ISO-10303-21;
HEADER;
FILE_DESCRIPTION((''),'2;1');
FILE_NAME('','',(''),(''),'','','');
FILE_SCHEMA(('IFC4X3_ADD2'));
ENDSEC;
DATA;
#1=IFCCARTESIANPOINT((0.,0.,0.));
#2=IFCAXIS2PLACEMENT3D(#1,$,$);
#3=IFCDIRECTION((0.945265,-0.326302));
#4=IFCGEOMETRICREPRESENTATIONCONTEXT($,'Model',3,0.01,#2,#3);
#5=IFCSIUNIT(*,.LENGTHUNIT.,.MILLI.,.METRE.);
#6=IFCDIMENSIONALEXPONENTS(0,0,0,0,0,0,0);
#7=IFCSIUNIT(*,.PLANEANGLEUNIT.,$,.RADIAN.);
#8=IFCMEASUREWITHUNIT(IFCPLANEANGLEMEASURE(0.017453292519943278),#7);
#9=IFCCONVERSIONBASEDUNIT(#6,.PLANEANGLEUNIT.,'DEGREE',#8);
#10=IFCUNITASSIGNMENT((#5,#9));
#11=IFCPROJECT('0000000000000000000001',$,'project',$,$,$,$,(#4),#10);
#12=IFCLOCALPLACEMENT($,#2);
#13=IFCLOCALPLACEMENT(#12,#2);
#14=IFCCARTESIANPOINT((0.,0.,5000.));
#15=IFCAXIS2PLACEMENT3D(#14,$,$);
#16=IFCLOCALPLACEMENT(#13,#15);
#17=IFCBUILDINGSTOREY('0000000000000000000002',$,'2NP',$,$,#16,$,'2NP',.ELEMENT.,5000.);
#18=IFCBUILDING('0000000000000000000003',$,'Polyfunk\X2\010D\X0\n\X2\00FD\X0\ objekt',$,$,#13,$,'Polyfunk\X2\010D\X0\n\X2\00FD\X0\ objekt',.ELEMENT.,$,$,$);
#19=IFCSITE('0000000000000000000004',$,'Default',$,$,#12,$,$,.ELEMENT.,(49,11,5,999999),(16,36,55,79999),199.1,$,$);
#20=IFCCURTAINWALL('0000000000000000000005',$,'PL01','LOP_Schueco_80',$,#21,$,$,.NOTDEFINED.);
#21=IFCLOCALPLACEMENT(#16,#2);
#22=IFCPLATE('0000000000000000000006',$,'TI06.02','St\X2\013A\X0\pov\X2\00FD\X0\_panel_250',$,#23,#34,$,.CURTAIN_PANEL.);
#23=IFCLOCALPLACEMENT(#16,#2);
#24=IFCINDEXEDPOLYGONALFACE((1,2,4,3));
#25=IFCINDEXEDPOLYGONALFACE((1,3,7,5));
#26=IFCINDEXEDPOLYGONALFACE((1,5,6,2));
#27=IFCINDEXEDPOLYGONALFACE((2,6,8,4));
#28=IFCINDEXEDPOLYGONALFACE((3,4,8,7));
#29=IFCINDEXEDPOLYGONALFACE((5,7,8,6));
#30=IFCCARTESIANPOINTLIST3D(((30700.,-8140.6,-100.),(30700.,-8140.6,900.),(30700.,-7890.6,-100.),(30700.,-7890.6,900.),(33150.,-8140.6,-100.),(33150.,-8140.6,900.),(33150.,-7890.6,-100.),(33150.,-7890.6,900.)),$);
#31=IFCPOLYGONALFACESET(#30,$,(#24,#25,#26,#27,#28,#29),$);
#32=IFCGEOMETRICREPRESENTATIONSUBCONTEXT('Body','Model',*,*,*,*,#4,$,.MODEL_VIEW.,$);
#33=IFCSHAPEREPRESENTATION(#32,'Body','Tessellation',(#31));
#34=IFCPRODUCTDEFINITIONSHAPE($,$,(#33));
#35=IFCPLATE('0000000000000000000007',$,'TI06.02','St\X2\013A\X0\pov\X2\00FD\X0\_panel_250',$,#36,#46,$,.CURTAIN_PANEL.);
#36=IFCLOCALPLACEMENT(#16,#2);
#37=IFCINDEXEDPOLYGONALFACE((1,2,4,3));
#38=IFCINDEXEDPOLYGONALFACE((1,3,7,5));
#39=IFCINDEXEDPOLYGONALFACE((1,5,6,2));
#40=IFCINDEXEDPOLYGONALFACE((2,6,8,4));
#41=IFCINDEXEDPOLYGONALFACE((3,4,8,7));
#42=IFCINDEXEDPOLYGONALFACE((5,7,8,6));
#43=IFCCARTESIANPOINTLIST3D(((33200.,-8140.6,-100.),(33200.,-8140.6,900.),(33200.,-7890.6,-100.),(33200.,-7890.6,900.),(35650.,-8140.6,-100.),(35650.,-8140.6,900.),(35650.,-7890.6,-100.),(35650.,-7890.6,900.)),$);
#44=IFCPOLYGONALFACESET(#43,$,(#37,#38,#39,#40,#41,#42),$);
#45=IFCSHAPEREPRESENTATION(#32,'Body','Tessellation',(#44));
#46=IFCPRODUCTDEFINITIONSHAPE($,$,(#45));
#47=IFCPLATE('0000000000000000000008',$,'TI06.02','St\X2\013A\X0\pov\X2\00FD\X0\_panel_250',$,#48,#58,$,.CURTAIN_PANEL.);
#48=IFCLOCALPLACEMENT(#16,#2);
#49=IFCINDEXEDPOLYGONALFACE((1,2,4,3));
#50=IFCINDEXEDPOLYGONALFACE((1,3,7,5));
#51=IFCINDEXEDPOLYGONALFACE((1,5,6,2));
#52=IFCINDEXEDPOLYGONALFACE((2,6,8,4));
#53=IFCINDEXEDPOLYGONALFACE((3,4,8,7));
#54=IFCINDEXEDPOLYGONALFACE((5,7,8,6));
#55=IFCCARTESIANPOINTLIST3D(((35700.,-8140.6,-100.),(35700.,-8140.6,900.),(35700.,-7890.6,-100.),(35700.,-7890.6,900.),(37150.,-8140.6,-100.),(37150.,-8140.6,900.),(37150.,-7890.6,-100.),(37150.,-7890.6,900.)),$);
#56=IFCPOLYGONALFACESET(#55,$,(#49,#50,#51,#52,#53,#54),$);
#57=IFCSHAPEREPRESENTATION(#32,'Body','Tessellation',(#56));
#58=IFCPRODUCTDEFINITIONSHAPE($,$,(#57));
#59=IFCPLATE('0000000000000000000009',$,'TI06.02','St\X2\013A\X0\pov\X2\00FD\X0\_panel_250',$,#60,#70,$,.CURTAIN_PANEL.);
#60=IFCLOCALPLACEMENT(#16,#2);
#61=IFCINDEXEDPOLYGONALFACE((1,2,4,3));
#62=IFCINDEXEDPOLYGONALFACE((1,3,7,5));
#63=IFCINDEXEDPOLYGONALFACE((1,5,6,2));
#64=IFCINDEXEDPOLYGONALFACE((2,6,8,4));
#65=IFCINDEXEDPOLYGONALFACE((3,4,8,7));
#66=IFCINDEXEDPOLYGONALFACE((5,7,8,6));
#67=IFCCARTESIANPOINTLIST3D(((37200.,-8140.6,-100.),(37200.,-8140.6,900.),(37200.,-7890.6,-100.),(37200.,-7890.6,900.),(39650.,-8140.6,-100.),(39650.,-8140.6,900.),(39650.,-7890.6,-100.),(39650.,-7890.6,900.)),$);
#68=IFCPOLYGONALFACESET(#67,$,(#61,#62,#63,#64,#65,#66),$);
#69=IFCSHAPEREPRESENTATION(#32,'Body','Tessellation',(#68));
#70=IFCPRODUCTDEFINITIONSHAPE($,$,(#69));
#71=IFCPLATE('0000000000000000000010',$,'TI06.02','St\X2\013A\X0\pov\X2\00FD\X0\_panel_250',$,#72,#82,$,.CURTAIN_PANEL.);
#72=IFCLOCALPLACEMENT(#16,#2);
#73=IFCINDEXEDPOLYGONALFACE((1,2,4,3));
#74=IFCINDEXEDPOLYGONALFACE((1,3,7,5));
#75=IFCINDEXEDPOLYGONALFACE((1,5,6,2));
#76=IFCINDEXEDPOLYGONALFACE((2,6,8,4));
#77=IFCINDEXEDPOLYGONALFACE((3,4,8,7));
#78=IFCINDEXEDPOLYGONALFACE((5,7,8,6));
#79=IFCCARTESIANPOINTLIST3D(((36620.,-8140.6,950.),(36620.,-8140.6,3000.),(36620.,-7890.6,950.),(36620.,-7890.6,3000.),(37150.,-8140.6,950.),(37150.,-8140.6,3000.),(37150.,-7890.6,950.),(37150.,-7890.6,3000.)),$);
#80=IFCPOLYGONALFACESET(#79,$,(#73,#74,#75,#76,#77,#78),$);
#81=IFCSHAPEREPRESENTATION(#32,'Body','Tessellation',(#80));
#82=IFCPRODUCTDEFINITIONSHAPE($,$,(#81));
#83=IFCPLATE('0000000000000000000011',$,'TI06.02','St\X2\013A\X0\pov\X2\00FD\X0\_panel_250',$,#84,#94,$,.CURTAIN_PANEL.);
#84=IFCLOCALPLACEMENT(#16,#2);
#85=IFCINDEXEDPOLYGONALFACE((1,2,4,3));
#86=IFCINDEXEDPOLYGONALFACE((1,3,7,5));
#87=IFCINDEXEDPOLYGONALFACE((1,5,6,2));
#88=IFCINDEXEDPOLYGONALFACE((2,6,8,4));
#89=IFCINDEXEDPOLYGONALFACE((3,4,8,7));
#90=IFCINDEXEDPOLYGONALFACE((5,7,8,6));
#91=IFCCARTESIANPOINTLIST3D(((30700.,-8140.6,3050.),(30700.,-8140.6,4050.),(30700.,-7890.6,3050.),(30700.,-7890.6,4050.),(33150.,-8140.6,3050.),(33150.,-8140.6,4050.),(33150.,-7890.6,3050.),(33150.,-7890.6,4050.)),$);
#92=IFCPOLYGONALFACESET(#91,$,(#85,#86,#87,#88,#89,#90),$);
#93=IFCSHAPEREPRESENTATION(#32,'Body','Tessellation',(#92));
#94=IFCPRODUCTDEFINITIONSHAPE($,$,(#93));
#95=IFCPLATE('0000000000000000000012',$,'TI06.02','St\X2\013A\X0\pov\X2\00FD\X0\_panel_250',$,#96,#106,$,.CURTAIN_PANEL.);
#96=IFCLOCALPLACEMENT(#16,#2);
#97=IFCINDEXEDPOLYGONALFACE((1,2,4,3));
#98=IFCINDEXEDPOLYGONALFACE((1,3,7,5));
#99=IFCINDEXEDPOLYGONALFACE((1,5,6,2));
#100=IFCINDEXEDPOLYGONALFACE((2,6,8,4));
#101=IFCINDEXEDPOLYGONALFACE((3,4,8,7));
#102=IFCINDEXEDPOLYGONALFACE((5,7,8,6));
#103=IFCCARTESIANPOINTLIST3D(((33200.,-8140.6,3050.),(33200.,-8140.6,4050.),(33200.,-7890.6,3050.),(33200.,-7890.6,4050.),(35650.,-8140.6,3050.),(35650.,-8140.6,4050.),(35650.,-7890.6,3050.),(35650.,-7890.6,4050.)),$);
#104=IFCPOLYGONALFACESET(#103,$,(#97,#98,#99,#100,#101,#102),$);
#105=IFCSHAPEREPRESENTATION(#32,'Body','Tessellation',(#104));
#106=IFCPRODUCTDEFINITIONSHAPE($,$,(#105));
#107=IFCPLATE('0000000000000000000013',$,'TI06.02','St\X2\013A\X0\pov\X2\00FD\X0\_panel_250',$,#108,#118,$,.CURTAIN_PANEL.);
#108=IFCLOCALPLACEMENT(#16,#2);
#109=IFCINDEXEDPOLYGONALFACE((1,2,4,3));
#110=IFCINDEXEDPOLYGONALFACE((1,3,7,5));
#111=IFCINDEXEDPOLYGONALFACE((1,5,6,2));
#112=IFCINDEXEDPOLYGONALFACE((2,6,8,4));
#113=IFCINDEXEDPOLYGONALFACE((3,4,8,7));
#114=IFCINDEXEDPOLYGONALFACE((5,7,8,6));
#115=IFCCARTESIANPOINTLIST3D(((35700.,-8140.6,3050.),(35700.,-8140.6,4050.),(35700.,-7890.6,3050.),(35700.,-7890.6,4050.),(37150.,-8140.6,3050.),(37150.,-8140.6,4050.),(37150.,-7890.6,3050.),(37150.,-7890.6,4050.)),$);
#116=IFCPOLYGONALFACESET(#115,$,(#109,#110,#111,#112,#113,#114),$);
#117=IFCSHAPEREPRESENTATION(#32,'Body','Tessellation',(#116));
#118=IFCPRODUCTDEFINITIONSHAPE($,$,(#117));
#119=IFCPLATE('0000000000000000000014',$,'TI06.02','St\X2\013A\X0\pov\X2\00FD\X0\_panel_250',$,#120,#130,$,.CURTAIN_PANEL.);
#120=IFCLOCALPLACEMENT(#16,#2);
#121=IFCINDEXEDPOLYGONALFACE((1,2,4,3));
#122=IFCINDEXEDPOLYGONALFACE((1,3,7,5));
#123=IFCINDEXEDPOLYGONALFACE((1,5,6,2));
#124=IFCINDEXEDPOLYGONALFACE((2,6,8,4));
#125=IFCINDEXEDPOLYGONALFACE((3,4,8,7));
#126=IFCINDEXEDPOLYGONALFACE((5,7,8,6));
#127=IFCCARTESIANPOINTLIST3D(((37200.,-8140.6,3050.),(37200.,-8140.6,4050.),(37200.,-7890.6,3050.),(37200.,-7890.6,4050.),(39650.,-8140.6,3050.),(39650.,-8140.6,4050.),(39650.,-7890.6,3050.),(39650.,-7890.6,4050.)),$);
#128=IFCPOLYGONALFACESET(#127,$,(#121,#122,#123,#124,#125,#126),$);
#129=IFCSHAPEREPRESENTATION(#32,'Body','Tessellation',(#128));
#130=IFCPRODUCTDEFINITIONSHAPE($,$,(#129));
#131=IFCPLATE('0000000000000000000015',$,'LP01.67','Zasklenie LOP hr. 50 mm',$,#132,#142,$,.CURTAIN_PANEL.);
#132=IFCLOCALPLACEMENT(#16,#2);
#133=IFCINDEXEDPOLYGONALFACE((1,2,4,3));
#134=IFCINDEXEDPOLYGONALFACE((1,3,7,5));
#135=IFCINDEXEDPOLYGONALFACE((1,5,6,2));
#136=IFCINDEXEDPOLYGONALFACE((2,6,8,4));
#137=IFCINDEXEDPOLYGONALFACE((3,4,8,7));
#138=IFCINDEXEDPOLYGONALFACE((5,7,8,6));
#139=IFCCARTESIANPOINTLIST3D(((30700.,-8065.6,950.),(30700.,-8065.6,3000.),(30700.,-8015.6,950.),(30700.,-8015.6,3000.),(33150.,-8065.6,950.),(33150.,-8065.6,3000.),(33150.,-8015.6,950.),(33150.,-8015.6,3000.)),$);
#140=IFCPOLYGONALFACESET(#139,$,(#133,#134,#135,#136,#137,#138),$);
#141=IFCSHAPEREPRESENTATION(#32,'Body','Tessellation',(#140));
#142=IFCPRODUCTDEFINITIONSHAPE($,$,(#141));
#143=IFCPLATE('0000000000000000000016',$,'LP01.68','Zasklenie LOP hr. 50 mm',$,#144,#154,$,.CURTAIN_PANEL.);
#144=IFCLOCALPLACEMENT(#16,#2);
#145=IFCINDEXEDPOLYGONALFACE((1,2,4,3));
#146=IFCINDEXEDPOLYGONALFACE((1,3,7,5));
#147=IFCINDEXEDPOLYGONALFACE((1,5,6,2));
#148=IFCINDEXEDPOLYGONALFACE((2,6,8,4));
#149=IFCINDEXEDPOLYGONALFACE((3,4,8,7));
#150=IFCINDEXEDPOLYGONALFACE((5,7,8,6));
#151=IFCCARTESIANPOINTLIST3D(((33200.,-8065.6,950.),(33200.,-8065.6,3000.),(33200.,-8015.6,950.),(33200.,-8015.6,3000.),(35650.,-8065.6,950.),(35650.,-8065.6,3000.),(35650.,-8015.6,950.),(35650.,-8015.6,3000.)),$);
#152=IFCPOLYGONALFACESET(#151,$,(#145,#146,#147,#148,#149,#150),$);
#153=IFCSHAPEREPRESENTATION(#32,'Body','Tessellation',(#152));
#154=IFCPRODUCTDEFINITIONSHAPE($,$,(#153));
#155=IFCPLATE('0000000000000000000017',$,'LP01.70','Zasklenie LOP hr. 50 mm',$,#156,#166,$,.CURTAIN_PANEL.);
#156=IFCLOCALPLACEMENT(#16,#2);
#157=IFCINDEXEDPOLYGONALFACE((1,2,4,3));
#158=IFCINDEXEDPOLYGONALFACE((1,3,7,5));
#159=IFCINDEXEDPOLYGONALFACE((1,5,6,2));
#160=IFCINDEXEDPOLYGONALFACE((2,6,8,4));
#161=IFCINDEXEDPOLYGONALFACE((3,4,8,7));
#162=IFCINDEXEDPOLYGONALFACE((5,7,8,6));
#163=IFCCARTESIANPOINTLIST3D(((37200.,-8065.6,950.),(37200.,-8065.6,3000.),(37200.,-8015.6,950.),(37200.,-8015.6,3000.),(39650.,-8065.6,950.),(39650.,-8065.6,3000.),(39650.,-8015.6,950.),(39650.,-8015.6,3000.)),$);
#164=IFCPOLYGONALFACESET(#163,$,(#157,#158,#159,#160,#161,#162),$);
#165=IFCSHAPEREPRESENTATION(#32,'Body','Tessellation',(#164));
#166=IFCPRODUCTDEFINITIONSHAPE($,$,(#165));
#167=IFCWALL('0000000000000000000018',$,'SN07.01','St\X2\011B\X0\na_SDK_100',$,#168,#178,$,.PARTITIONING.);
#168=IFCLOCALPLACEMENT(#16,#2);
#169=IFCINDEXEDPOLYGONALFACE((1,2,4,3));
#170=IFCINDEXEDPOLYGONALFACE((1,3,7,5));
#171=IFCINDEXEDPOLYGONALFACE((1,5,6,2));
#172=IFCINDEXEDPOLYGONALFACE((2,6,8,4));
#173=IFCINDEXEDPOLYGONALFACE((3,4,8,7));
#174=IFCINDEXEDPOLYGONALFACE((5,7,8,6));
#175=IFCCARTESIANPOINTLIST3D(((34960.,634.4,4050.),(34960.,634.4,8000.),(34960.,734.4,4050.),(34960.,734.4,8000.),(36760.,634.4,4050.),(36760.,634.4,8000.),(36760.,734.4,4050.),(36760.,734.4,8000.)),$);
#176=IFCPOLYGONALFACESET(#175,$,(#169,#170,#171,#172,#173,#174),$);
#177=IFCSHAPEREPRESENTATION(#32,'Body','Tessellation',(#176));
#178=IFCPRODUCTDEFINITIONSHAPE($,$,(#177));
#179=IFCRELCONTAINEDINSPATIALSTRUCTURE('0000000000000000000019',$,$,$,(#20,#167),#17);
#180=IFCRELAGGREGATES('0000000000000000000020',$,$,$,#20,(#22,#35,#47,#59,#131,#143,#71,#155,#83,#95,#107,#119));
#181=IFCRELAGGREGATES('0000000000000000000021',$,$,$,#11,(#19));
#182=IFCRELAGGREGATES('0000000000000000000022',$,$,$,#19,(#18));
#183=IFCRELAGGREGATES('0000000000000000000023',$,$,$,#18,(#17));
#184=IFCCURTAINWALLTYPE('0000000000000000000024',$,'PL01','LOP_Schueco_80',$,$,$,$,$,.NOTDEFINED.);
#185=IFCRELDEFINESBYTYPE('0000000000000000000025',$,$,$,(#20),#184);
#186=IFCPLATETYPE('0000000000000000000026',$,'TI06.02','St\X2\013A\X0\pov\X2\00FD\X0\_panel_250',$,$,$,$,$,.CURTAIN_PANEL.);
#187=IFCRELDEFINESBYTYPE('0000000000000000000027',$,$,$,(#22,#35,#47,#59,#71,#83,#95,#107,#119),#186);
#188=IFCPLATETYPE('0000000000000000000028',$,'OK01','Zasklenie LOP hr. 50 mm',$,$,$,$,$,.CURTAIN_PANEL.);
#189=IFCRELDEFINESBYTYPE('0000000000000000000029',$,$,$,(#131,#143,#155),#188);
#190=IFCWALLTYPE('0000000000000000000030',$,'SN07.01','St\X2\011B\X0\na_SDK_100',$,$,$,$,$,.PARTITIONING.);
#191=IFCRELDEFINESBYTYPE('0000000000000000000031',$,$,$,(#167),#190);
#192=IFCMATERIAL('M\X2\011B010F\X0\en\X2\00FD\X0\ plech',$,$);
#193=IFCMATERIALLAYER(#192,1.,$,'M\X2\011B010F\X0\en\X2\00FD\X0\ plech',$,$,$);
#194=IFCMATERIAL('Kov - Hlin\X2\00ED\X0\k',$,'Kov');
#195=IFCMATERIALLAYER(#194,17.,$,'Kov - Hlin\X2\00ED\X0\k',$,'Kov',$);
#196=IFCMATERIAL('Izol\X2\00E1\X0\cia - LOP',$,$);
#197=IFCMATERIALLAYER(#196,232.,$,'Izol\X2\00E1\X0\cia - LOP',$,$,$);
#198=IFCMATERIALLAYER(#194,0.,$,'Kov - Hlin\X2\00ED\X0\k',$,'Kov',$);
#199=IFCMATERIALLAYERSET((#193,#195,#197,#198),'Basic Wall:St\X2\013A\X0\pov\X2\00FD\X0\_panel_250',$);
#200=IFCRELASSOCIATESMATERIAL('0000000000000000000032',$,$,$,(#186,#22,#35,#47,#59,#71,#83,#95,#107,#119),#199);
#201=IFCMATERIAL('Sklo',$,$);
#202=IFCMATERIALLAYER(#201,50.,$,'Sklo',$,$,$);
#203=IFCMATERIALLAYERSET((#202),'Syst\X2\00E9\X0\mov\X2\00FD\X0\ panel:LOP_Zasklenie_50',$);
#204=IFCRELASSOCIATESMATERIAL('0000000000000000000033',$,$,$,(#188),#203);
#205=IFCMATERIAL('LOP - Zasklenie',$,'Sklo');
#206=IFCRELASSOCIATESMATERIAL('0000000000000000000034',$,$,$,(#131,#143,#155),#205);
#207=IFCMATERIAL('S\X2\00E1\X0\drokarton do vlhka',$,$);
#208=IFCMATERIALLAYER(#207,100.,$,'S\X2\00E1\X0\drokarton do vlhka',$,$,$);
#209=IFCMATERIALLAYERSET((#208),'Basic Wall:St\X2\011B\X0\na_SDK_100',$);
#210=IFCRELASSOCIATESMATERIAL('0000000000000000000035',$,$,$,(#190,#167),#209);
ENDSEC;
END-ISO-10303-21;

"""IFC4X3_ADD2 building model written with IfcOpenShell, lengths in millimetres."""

from ifc_helpers import new_model, entity, si_unit, converted_unit, direction, frame, frame_2d, origin, origin_2d_with_axis, place, context, subcontext, project, spatial, polyline, rectangle, extrude, clip, bounded_halfspace, source, transform, mapped, material, layer, layer_set, layer_usage, type_object, type_shapes, element, aggregate, save


model = new_model("IFC4X3_ADD2")

# Units and contexts
model_context = context("Model", 3, precision=0.01, world=origin(), true_north=direction((0.945265, -0.326302)))
body_context = subcontext(model_context, "Body", "Model", "MODEL_VIEW")
ifc_project = project(units=[si_unit("LENGTHUNIT", "METRE", prefix="MILLI"), converted_unit("PLANEANGLEUNIT", "DEGREE", entity("IfcPlaneAngleMeasure", 0.017453292519943278), si_unit("PLANEANGLEUNIT", "RADIAN"), dimensions=[0, 0, 0, 0, 0, 0, 0])], contexts=[model_context])

# Site, building, storey
site_placement = place(None, origin())
site = spatial("IfcSite", under=ifc_project, at=site_placement, Name="Default", CompositionType="ELEMENT", RefLatitude=(49, 11, 5, 999999), RefLongitude=(16, 36, 55, 79999), RefElevation=199.1)
building_placement = place(site_placement, origin())
building = spatial("IfcBuilding", under=site, at=building_placement, Name="Polyfunkčný objekt", LongName="Polyfunkčný objekt", CompositionType="ELEMENT")
storey_placement = place(building_placement, frame((0.0, 0.0, 5000.0)))
storey = spatial("IfcBuildingStorey", under=building, at=storey_placement, Name="2NP", LongName="2NP", CompositionType="ELEMENT", Elevation=5000.0)

# Curtain wall, plates
curtain_wall_type = type_object("IfcCurtainWallType", Name="PL01", Description="LOP_Schueco_80", PredefinedType="NOTDEFINED")
curtain_wall_placement = place(storey_placement, frame((0.0, 0.0, -5000.0)))
curtain_wall = element("IfcCurtainWall", 1, at=curtain_wall_placement, inside=storey, type_object=curtain_wall_type, Name="PL01", Description="LOP_Schueco_80", PredefinedType="NOTDEFINED")
ifc_material_1 = material(Name="Měďený plech")
ifc_layer_1 = layer(ifc_material_1, 1.0, Name="Měďený plech")
ifc_material_2 = material(Name="Kov - Hliník", Category="Kov")
ifc_layer_2 = layer(ifc_material_2, 17.0, Name="Kov - Hliník", Category="Kov")
ifc_material_3 = material(Name="Izolácia - LOP")
ifc_layer_3 = layer(ifc_material_3, 232.0, Name="Izolácia - LOP")
ifc_layer_4 = layer(ifc_material_2, 0.0, Name="Kov - Hliník", Category="Kov")
ifc_layer_set_1 = layer_set([ifc_layer_1, ifc_layer_2, ifc_layer_3, ifc_layer_4], Name="Basic Wall:Stĺpový_panel_250")
ifc_layer_usage_1 = layer_usage(ifc_layer_set_1, "AXIS2", "POSITIVE", -125.0)
plate_type_1 = type_object("IfcPlateType", Name="TI06.02", Description="Stĺpový_panel_250", PredefinedType="CURTAIN_PANEL", material=ifc_layer_set_1)
plate_1_placement = place(storey_placement, frame((30700.0, -8015.6, -100.0)))
plate_1 = element("IfcPlate", 2, at=plate_1_placement, type_object=plate_type_1, material=ifc_layer_usage_1, Name="TI06.02", Description="Stĺpový_panel_250", PredefinedType="CURTAIN_PANEL", context=body_context, shape_type="SweptSolid", body=[
    extrude(rectangle(XDim=250.0, YDim=2450.0, at=frame_2d((0.0, 0.0), x_axis=(1.0, 0.0))), frame((1225.0, 0.0, 0.0), z_axis=(0.0, 0.0, 1.0), x_axis=(0.0, 1.0, 0.0)), (0.0, 0.0, 1.0), 1000.0),
])
ifc_layer_usage_2 = layer_usage(ifc_layer_set_1, "AXIS2", "POSITIVE", -125.0)
plate_2_placement = place(storey_placement, frame((33200.0, -8015.6, -100.0)))
plate_2 = element("IfcPlate", 3, at=plate_2_placement, type_object=plate_type_1, material=ifc_layer_usage_2, Name="TI06.02", Description="Stĺpový_panel_250", PredefinedType="CURTAIN_PANEL", context=body_context, shape_type="SweptSolid", body=[
    extrude(rectangle(XDim=250.0, YDim=2450.0, at=frame_2d((0.0, 0.0), x_axis=(1.0, 0.0))), frame((1225.0, 0.0, 0.0), z_axis=(0.0, 0.0, 1.0), x_axis=(0.0, 1.0, 0.0)), (0.0, 0.0, 1.0), 1000.0),
])
ifc_layer_usage_3 = layer_usage(ifc_layer_set_1, "AXIS2", "POSITIVE", -125.0)
plate_3_placement = place(storey_placement, frame((35700.0, -8015.6, -100.0)))
plate_3 = element("IfcPlate", 4, at=plate_3_placement, type_object=plate_type_1, material=ifc_layer_usage_3, Name="TI06.02", Description="Stĺpový_panel_250", PredefinedType="CURTAIN_PANEL", context=body_context, shape_type="SweptSolid", body=[
    extrude(rectangle(XDim=250.0, YDim=1450.0, at=frame_2d((0.0, 0.0), x_axis=(1.0, 0.0))), frame((725.0, 0.0, 0.0), z_axis=(0.0, 0.0, 1.0), x_axis=(0.0, 1.0, 0.0)), (0.0, 0.0, 1.0), 1000.0),
])
ifc_layer_usage_4 = layer_usage(ifc_layer_set_1, "AXIS2", "POSITIVE", -125.0)
plate_4_placement = place(storey_placement, frame((37200.0, -8015.6, -100.0)))
plate_4 = element("IfcPlate", 5, at=plate_4_placement, type_object=plate_type_1, material=ifc_layer_usage_4, Name="TI06.02", Description="Stĺpový_panel_250", PredefinedType="CURTAIN_PANEL", context=body_context, shape_type="SweptSolid", body=[
    extrude(rectangle(XDim=250.0, YDim=2450.0, at=frame_2d((0.0, 0.0), x_axis=(1.0, 0.0))), frame((1225.0, 0.0, 0.0), z_axis=(0.0, 0.0, 1.0), x_axis=(0.0, 1.0, 0.0)), (0.0, 0.0, 1.0), 1000.0),
])
ifc_layer_usage_5 = layer_usage(ifc_layer_set_1, "AXIS2", "POSITIVE", -125.0)
plate_5_placement = place(storey_placement, frame((36620.0, -8015.6, 950.0)))
plate_5 = element("IfcPlate", 6, at=plate_5_placement, type_object=plate_type_1, material=ifc_layer_usage_5, Name="TI06.02", Description="Stĺpový_panel_250", PredefinedType="CURTAIN_PANEL", context=body_context, shape_type="SweptSolid", body=[
    extrude(rectangle(XDim=250.0, YDim=530.0, at=frame_2d((0.0, 0.0), x_axis=(1.0, 0.0))), frame((265.0, 0.0, 0.0), z_axis=(0.0, 0.0, 1.0), x_axis=(0.0, 1.0, 0.0)), (0.0, 0.0, 1.0), 2050.0),
])
ifc_layer_usage_6 = layer_usage(ifc_layer_set_1, "AXIS2", "POSITIVE", -125.0)
plate_6_placement = place(storey_placement, frame((30700.0, -8015.6, 3050.0)))
plate_6 = element("IfcPlate", 7, at=plate_6_placement, type_object=plate_type_1, material=ifc_layer_usage_6, Name="TI06.02", Description="Stĺpový_panel_250", PredefinedType="CURTAIN_PANEL", context=body_context, shape_type="SweptSolid", body=[
    extrude(rectangle(XDim=250.0, YDim=2450.0, at=frame_2d((0.0, 0.0), x_axis=(1.0, 0.0))), frame((1225.0, 0.0, 0.0), z_axis=(0.0, 0.0, 1.0), x_axis=(0.0, 1.0, 0.0)), (0.0, 0.0, 1.0), 1000.0),
])
ifc_layer_usage_7 = layer_usage(ifc_layer_set_1, "AXIS2", "POSITIVE", -125.0)
plate_7_placement = place(storey_placement, frame((33200.0, -8015.6, 3050.0)))
plate_7 = element("IfcPlate", 8, at=plate_7_placement, type_object=plate_type_1, material=ifc_layer_usage_7, Name="TI06.02", Description="Stĺpový_panel_250", PredefinedType="CURTAIN_PANEL", context=body_context, shape_type="SweptSolid", body=[
    extrude(rectangle(XDim=250.0, YDim=2450.0, at=frame_2d((0.0, 0.0), x_axis=(1.0, 0.0))), frame((1225.0, 0.0, 0.0), z_axis=(0.0, 0.0, 1.0), x_axis=(0.0, 1.0, 0.0)), (0.0, 0.0, 1.0), 1000.0),
])
ifc_layer_usage_8 = layer_usage(ifc_layer_set_1, "AXIS2", "POSITIVE", -125.0)
plate_8_placement = place(storey_placement, frame((35700.0, -8015.6, 3050.0)))
plate_8 = element("IfcPlate", 9, at=plate_8_placement, type_object=plate_type_1, material=ifc_layer_usage_8, Name="TI06.02", Description="Stĺpový_panel_250", PredefinedType="CURTAIN_PANEL", context=body_context, shape_type="SweptSolid", body=[
    extrude(rectangle(XDim=250.0, YDim=1450.0, at=frame_2d((0.0, 0.0), x_axis=(1.0, 0.0))), frame((725.0, 0.0, 0.0), z_axis=(0.0, 0.0, 1.0), x_axis=(0.0, 1.0, 0.0)), (0.0, 0.0, 1.0), 1000.0),
])
ifc_layer_usage_9 = layer_usage(ifc_layer_set_1, "AXIS2", "POSITIVE", -125.0)
plate_9_placement = place(storey_placement, frame((37200.0, -8015.6, 3050.0)))
plate_9 = element("IfcPlate", 10, at=plate_9_placement, type_object=plate_type_1, material=ifc_layer_usage_9, Name="TI06.02", Description="Stĺpový_panel_250", PredefinedType="CURTAIN_PANEL", context=body_context, shape_type="SweptSolid", body=[
    extrude(rectangle(XDim=250.0, YDim=2450.0, at=frame_2d((0.0, 0.0), x_axis=(1.0, 0.0))), frame((1225.0, 0.0, 0.0), z_axis=(0.0, 0.0, 1.0), x_axis=(0.0, 1.0, 0.0)), (0.0, 0.0, 1.0), 1000.0),
])
ifc_material_4 = material(Name="LOP - Zasklenie", Category="Sklo")
ifc_material_5 = material(Name="Sklo")
ifc_layer_5 = layer(ifc_material_5, 50.0, Name="Sklo")
ifc_layer_set_2 = layer_set([ifc_layer_5], Name="Systémový panel:LOP_Zasklenie_50")
plate_type_2 = type_object("IfcPlateType", Name="OK01", Description="Zasklenie LOP hr. 50 mm", PredefinedType="CURTAIN_PANEL", material=ifc_layer_set_2)
shared_shape_1 = source(origin(), body_context, "Body", "SweptSolid", [
    extrude(rectangle(XDim=50.0, YDim=2450.0, at=origin_2d_with_axis()), frame((0.0, -25.0, 0.0), z_axis=(0.0, 0.0, 1.0), x_axis=(0.0, 1.0, 0.0)), (0.0, 0.0, 1.0), 2050.0),
])
type_shapes(plate_type_2, [shared_shape_1])
plate_10_placement = place(curtain_wall_placement, frame((31925.0, -8015.6, 5950.0)))
plate_10 = element("IfcPlate", 11, at=plate_10_placement, type_object=plate_type_2, material=ifc_material_4, Name="LP01.67", Description="Zasklenie LOP hr. 50 mm", PredefinedType="CURTAIN_PANEL", context=body_context, shape_type="MappedRepresentation", body=[
    mapped(shared_shape_1, transform((0.0, 0.0, 0.0), scale=1.0)),
])
plate_11_placement = place(curtain_wall_placement, frame((34425.0, -8015.6, 5950.0)))
plate_11 = element("IfcPlate", 12, at=plate_11_placement, type_object=plate_type_2, material=ifc_material_4, Name="LP01.68", Description="Zasklenie LOP hr. 50 mm", PredefinedType="CURTAIN_PANEL", context=body_context, shape_type="MappedRepresentation", body=[
    mapped(shared_shape_1, transform((0.0, 0.0, 0.0), scale=1.0)),
])
plate_12_placement = place(curtain_wall_placement, frame((38425.0, -8015.6, 5950.0)))
plate_12 = element("IfcPlate", 13, at=plate_12_placement, type_object=plate_type_2, material=ifc_material_4, Name="LP01.70", Description="Zasklenie LOP hr. 50 mm", PredefinedType="CURTAIN_PANEL", context=body_context, shape_type="MappedRepresentation", body=[
    mapped(shared_shape_1, transform((0.0, 0.0, 0.0), scale=1.0)),
])

# Wall
ifc_material_6 = material(Name="Sádrokarton do vlhka")
ifc_layer_6 = layer(ifc_material_6, 100.0, Name="Sádrokarton do vlhka")
ifc_layer_set_3 = layer_set([ifc_layer_6], Name="Basic Wall:Stěna_SDK_100")
wall_type_1 = type_object("IfcWallType", Name="SN07.01", Description="Stěna_SDK_100", PredefinedType="PARTITIONING", material=ifc_layer_set_3)
wall_1_placement = place(storey_placement, frame((34960.0, 684.4, 4050.0)))
element("IfcWall", 14, at=wall_1_placement, inside=storey, type_object=wall_type_1, material=ifc_layer_set_3, Name="SN07.01", Description="Stěna_SDK_100", PredefinedType="PARTITIONING", context=body_context, shape_type="Clipping", body=[
    clip(clip(extrude(rectangle(XDim=1800.0, YDim=100.0, at=frame_2d((900.0, 0.0), x_axis=(-1.0, 0.0))), origin(), (0.0, 0.0, 1.0), 3950.0), bounded_halfspace(frame((1800.0, -50.0, 0.0), z_axis=(0.0, 0.0, 1.0), x_axis=(-1.0, 0.0, 0.0)), True, frame((1800.0, -50.0, 0.0)), polyline([(0.0, 0.0), (0.0, 100.0), (-1800.0, 100.0), (-1800.0, 0.0), (0.0, 0.0)]))), bounded_halfspace(frame((0.0, -50.0, 3950.0), z_axis=(0.0, 0.0, -1.0), x_axis=(1.0, 0.0, 0.0)), True, frame((0.0, -50.0, 3950.0)), polyline([(0.0, 0.0), (1800.0, 0.0), (1800.0, 100.0), (0.0, 100.0), (0.0, 0.0)]))),
])

aggregate(curtain_wall, [plate_1, plate_2, plate_3, plate_4, plate_10, plate_11, plate_5, plate_12, plate_6, plate_7, plate_8, plate_9])

save(model, "model.ifc")
